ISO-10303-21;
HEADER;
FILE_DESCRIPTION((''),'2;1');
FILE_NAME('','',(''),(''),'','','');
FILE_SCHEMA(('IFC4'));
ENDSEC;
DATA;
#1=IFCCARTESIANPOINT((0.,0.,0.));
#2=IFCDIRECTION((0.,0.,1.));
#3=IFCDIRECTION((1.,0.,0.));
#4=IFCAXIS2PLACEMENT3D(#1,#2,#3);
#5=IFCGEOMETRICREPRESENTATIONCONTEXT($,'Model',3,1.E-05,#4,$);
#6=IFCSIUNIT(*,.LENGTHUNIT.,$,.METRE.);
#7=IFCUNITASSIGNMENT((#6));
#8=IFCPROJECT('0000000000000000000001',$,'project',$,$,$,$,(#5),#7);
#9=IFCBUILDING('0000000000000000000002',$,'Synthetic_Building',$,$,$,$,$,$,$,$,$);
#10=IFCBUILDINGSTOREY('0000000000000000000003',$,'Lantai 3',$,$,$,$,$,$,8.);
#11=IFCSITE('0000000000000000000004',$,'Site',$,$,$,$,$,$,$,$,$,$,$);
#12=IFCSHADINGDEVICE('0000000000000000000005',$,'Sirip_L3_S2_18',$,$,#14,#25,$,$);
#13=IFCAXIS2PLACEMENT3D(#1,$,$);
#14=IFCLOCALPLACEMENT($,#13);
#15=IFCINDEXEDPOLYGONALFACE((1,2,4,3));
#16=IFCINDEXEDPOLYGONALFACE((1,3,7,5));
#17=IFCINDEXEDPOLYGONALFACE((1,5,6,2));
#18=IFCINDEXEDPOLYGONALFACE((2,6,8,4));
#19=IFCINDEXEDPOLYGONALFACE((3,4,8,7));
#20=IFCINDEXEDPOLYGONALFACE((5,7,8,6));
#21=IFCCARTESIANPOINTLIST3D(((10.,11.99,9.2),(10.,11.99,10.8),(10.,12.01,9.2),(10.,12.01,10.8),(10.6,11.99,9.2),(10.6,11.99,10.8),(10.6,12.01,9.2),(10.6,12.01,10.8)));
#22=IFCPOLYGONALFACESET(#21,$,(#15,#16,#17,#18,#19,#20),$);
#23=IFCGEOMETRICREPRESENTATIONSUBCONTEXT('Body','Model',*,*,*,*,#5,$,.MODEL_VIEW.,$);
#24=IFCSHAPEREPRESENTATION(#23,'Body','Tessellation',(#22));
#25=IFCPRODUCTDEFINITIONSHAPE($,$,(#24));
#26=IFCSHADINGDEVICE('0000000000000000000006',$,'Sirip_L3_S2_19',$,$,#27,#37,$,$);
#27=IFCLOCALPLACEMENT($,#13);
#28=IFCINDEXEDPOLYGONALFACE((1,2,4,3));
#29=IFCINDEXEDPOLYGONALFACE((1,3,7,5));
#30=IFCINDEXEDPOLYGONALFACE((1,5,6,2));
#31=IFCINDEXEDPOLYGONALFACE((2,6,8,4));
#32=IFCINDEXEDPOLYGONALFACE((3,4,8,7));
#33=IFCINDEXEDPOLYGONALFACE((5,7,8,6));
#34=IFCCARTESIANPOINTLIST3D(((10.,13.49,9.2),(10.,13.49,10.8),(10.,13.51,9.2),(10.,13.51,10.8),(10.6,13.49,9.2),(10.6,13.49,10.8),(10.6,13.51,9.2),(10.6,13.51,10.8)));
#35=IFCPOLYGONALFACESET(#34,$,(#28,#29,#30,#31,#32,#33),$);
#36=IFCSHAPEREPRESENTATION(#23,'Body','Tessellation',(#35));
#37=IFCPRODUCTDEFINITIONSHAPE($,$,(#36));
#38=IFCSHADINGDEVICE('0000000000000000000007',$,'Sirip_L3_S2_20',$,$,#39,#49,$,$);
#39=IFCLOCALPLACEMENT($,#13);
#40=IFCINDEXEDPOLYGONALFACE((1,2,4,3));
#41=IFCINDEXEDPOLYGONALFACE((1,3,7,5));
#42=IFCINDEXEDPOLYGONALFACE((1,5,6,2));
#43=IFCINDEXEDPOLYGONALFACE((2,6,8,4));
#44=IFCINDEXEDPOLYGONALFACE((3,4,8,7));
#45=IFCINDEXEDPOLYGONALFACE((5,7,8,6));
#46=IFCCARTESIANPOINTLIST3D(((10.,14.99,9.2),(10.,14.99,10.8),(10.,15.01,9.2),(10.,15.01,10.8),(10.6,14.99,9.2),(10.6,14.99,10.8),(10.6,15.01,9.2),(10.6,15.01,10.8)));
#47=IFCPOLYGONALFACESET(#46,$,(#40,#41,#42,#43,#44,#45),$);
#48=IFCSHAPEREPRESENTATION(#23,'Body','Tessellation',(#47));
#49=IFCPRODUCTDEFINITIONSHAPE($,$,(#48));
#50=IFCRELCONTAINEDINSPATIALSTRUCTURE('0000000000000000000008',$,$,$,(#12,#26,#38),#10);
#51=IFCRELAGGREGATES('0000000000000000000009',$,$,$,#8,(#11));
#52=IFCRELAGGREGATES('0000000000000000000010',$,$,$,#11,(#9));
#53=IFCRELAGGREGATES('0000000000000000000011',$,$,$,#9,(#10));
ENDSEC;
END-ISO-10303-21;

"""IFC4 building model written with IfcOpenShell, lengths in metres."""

from ifc_helpers import new_model, si_unit, frame, origin_with_axes, place, context, subcontext, project, spatial, polyline, outline, extrude, element, save


model = new_model("IFC4")

# Units and contexts
model_context = context("Model", 3, precision=1e-05, world=origin_with_axes())
body_context = subcontext(model_context, "Body", "Model", "MODEL_VIEW")
ifc_project = project(units=[si_unit("LENGTHUNIT", "METRE")], contexts=[model_context])

# Site, building, storey
site = spatial("IfcSite", under=ifc_project, Name="Site")
building = spatial("IfcBuilding", under=site, Name="Synthetic_Building")
storey = spatial("IfcBuildingStorey", under=building, Name="Lantai 3", Elevation=8.0)

# Shading devices
shading_device_1_placement = place(None, origin_with_axes())
element("IfcShadingDevice", 1, at=shading_device_1_placement, inside=storey, Name="Sirip_L3_S2_18", context=body_context, shape_type="SweptSolid", body=[
    extrude(outline(polyline([(10.0, 11.99), (10.0, 12.01), (10.6, 12.01), (10.6, 11.99), (10.0, 11.99)])), frame((0.0, 0.0, 9.2), z_axis=(0.0, 0.0, 1.0), x_axis=(1.0, 0.0, 0.0)), (0.0, 0.0, 1.0), 1.6),
])
shading_device_2_placement = place(None, origin_with_axes())
element("IfcShadingDevice", 2, at=shading_device_2_placement, inside=storey, Name="Sirip_L3_S2_19", context=body_context, shape_type="SweptSolid", body=[
    extrude(outline(polyline([(10.0, 13.49), (10.0, 13.51), (10.6, 13.51), (10.6, 13.49), (10.0, 13.49)])), frame((0.0, 0.0, 9.2), z_axis=(0.0, 0.0, 1.0), x_axis=(1.0, 0.0, 0.0)), (0.0, 0.0, 1.0), 1.6),
])
shading_device_3_placement = place(None, origin_with_axes())
element("IfcShadingDevice", 3, at=shading_device_3_placement, inside=storey, Name="Sirip_L3_S2_20", context=body_context, shape_type="SweptSolid", body=[
    extrude(outline(polyline([(10.0, 14.99), (10.0, 15.01), (10.6, 15.01), (10.6, 14.99), (10.0, 14.99)])), frame((0.0, 0.0, 9.2), z_axis=(0.0, 0.0, 1.0), x_axis=(1.0, 0.0, 0.0)), (0.0, 0.0, 1.0), 1.6),
])

save(model, "model.ifc")
